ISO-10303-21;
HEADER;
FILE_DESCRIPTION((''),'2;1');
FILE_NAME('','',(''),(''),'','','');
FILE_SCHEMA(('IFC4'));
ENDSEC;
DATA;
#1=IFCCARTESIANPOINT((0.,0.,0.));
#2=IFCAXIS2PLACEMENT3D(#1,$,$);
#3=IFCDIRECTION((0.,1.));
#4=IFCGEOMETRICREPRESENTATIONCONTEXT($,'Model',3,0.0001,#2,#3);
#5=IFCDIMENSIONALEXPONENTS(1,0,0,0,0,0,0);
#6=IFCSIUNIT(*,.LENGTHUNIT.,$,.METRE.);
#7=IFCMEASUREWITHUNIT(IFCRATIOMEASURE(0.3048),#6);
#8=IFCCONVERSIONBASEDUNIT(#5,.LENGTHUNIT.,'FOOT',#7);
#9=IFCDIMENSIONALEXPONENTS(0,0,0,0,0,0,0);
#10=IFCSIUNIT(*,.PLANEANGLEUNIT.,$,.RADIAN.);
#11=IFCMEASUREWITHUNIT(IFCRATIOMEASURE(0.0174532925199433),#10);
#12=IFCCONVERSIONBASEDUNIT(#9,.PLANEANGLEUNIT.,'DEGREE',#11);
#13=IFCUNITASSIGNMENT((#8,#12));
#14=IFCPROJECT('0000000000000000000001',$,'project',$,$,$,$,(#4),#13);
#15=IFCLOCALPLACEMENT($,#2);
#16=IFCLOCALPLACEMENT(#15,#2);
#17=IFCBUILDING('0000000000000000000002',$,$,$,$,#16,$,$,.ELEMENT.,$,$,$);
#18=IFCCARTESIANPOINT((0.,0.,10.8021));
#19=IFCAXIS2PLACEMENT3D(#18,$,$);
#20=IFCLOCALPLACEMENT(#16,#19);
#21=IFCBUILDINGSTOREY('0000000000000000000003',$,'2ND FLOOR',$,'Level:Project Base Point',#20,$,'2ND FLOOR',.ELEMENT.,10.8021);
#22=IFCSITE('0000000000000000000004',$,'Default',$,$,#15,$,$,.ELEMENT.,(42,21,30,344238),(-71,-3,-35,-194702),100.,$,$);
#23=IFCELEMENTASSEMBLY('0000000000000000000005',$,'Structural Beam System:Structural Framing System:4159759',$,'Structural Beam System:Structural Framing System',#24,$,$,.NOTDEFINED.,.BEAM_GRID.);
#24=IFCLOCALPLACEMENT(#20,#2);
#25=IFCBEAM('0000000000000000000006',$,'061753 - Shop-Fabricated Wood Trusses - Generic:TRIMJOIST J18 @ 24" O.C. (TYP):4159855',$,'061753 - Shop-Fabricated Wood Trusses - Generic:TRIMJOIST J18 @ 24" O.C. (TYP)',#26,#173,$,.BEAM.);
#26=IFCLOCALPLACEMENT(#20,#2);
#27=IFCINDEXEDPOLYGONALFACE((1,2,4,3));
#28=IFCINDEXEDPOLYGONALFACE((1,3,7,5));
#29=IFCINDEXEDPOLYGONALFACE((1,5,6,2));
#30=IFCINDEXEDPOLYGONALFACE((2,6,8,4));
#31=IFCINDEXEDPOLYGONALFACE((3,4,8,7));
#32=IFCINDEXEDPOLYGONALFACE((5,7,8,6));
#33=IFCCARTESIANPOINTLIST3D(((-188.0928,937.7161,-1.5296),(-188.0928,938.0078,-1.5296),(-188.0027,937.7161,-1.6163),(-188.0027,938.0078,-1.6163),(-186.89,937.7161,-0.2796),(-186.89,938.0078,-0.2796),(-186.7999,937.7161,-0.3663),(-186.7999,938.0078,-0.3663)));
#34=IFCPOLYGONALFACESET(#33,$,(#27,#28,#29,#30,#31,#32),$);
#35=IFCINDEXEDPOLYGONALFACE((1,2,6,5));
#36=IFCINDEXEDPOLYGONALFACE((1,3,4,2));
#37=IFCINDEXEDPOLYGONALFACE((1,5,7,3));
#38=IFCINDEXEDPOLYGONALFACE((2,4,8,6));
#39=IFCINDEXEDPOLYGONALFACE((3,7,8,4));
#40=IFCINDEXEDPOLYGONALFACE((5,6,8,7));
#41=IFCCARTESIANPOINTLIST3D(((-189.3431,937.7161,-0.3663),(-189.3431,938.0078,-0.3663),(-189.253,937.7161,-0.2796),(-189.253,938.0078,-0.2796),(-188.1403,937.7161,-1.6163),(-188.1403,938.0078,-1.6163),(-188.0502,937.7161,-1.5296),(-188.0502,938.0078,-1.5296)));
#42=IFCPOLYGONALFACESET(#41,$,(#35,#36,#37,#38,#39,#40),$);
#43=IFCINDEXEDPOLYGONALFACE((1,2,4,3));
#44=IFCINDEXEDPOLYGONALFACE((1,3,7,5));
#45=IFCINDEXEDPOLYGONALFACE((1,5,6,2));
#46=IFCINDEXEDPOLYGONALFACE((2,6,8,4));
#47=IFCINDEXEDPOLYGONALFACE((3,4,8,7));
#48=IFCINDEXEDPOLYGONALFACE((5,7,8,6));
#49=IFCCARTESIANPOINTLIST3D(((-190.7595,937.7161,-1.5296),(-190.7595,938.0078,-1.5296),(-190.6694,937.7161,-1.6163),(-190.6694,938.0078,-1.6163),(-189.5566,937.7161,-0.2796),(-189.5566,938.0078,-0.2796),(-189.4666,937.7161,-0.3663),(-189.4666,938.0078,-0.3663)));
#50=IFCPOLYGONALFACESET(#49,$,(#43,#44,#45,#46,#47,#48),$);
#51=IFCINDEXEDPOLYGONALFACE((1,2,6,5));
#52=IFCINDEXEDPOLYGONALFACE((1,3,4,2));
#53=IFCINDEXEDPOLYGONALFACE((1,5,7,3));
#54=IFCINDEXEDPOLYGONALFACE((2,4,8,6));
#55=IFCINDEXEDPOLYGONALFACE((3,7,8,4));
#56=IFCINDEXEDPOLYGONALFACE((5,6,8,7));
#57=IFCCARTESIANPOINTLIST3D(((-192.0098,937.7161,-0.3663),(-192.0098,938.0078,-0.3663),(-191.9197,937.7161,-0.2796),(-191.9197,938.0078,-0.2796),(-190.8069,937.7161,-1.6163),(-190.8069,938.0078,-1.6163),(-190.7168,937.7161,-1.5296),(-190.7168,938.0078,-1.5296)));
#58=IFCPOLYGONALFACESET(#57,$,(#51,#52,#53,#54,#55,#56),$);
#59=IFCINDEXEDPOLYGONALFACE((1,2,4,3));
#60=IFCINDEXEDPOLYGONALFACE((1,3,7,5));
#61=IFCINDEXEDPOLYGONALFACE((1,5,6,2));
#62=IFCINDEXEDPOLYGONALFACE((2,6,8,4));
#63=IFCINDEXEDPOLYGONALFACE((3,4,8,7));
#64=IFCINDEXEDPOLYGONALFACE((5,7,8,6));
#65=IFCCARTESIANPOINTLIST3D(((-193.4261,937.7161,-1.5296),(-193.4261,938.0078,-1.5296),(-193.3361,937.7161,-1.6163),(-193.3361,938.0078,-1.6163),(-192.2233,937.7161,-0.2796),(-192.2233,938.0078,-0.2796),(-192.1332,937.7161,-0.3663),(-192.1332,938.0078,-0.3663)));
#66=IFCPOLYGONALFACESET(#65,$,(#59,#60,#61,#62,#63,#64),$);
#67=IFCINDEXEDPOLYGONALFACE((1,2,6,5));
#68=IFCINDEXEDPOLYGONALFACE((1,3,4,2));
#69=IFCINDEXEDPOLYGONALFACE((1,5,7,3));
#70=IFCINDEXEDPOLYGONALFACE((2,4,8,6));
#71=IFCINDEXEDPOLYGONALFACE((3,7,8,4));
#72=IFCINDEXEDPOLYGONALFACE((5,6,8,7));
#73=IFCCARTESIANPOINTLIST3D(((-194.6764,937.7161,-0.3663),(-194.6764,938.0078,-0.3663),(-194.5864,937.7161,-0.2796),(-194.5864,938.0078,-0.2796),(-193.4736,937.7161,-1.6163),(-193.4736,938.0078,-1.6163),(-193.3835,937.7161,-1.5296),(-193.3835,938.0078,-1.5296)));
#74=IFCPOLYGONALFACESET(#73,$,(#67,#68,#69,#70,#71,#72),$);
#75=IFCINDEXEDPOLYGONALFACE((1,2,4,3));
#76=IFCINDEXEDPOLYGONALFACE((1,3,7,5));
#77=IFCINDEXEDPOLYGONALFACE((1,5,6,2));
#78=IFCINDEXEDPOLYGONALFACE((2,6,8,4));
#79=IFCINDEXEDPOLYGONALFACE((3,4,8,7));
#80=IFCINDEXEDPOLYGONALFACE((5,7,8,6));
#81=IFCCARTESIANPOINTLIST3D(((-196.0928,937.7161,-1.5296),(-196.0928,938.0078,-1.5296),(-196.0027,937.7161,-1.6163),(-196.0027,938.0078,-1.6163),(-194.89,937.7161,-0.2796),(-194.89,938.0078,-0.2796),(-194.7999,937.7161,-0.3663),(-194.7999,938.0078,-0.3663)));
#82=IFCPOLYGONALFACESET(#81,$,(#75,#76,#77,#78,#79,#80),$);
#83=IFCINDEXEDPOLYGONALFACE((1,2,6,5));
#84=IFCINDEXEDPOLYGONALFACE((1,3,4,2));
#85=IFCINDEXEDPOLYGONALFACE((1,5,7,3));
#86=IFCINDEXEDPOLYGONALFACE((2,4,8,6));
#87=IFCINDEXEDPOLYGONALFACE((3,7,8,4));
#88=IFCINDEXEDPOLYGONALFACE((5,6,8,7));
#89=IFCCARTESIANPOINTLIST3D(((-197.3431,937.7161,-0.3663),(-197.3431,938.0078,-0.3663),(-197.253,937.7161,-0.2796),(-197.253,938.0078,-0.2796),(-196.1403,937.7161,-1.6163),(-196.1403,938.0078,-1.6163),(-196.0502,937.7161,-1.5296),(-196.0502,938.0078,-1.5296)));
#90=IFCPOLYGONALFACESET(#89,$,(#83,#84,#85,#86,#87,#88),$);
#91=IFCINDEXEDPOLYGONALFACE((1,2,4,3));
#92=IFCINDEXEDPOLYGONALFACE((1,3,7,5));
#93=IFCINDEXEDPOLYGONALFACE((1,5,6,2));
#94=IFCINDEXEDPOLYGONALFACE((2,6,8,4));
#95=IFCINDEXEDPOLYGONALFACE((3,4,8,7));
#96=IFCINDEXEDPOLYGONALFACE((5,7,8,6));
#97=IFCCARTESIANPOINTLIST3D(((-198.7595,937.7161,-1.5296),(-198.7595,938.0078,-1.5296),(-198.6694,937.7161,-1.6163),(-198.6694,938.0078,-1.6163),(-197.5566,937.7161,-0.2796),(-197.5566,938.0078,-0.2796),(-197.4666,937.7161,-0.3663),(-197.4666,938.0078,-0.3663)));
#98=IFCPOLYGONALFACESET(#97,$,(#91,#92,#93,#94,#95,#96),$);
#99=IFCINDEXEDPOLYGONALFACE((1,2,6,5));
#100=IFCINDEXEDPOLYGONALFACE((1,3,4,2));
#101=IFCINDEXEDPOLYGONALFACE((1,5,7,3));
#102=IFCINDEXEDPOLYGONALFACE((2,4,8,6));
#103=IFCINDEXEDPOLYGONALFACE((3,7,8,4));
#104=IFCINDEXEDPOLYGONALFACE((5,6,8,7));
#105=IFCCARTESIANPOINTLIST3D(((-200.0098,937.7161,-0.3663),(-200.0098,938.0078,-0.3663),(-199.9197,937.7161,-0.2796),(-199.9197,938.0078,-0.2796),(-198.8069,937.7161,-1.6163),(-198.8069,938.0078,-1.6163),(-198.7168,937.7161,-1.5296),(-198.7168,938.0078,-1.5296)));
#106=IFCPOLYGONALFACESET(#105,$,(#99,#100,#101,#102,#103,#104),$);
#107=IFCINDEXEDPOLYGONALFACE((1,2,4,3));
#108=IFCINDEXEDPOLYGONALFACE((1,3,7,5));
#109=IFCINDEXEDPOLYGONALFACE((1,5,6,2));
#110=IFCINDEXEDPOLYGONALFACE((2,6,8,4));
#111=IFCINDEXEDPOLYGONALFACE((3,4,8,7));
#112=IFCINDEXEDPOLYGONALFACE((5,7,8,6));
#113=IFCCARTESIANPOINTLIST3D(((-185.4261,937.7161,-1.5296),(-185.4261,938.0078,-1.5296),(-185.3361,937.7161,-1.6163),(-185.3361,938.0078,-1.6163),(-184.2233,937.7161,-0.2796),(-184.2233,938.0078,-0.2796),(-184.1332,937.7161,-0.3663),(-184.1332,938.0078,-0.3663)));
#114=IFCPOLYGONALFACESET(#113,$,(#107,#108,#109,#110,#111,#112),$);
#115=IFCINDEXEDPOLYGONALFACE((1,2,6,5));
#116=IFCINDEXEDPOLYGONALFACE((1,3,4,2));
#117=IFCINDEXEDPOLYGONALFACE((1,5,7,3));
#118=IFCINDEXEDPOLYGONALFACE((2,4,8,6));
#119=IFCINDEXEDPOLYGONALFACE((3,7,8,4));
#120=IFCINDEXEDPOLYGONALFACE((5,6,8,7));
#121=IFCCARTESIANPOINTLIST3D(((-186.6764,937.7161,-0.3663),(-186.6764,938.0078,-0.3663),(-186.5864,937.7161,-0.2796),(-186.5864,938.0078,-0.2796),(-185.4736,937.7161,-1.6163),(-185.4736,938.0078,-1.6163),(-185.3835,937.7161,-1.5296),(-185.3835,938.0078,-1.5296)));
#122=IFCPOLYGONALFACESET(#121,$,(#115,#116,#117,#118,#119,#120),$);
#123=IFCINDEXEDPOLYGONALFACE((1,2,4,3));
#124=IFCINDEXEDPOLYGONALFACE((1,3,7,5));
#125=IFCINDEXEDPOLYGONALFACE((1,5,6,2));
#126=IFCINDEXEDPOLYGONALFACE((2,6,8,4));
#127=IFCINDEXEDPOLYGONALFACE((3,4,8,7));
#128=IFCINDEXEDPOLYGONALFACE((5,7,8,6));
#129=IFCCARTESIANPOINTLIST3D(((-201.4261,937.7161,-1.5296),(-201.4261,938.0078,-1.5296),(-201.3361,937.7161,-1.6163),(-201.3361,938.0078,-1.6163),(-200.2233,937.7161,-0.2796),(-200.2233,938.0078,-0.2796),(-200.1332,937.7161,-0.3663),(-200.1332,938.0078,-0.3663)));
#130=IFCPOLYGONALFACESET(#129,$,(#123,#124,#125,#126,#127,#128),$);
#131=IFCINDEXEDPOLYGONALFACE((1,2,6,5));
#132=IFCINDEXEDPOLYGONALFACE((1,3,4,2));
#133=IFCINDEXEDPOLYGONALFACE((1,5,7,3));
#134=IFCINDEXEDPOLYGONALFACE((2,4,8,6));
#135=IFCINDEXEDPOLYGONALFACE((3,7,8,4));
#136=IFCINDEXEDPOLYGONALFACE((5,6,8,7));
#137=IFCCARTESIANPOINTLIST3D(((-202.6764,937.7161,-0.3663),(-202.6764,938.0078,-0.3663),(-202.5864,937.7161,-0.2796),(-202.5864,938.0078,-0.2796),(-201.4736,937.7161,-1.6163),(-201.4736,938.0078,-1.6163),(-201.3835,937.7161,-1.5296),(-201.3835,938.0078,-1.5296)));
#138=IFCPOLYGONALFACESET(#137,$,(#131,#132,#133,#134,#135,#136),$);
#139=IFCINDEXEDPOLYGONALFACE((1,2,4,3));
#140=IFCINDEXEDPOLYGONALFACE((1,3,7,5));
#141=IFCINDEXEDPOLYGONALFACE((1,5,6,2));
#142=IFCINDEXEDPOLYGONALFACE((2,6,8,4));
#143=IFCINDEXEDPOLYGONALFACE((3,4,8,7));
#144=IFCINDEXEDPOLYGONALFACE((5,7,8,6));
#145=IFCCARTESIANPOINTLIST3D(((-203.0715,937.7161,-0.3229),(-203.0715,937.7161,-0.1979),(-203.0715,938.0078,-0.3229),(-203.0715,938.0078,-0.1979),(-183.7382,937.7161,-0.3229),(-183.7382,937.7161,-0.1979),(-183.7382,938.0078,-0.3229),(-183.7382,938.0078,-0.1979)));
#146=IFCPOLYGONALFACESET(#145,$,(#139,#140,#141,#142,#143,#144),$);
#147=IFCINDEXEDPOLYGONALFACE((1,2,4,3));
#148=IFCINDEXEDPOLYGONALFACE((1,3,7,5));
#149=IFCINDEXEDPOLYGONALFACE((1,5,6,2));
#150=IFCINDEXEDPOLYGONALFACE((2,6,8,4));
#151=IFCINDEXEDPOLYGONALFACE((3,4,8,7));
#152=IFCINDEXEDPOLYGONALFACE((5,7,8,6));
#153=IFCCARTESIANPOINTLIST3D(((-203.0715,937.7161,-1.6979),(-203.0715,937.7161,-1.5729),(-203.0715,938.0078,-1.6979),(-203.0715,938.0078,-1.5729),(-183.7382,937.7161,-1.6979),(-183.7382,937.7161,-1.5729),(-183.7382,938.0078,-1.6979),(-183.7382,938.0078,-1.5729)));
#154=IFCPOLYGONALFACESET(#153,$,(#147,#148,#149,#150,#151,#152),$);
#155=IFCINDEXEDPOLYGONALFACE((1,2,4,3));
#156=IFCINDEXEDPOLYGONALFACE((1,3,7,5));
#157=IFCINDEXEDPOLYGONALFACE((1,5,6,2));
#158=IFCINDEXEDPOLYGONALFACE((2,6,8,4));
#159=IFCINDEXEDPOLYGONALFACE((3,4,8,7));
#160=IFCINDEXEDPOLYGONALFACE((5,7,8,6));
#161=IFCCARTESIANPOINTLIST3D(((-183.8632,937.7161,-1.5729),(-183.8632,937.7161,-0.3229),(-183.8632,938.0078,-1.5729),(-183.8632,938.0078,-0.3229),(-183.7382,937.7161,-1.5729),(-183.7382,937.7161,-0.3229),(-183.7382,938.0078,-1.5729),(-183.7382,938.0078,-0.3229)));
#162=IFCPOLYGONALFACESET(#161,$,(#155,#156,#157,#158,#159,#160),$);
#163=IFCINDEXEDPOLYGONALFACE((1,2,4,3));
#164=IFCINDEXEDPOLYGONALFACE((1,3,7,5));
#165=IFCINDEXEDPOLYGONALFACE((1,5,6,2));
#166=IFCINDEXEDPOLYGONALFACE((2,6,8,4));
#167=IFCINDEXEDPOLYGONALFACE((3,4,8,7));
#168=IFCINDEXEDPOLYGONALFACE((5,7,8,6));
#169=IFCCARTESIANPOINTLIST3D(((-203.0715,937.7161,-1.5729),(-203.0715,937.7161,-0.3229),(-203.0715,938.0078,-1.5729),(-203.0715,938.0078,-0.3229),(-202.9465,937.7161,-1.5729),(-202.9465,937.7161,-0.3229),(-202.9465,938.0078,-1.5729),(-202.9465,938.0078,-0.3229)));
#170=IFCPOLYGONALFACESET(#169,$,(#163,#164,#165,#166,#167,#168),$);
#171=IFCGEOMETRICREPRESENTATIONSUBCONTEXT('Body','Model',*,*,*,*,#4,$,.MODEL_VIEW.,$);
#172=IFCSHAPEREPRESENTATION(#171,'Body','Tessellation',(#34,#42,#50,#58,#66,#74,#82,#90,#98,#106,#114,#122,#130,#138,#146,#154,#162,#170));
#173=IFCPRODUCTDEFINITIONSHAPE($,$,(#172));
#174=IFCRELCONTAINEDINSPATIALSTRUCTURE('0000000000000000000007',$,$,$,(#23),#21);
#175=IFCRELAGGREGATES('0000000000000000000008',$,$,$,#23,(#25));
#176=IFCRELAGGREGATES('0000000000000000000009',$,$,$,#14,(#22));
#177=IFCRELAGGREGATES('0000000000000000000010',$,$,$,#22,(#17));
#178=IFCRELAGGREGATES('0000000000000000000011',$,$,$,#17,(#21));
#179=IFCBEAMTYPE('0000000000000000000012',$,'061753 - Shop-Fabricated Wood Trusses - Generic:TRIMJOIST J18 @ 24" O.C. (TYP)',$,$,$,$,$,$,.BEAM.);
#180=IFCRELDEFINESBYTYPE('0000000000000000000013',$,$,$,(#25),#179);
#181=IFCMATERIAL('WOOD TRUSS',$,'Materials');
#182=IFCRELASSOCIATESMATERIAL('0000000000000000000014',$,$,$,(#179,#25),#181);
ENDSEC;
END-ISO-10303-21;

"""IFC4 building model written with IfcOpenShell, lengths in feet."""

from ifc_helpers import new_model, entity, si_unit, converted_unit, direction, frame, frame_2d, origin, origin_2d_with_axis, place, context, subcontext, project, spatial, rectangle, extrude, source, transform, mapped, material, material_profile, profile_set, profile_usage, type_object, type_shapes, element, aggregate, save


model = new_model("IFC4")

# Units and contexts
model_context = context("Model", 3, precision=0.0001, world=origin(), true_north=direction((0.0, 1.0)))
body_context = subcontext(model_context, "Body", "Model", "MODEL_VIEW")
ifc_project = project(units=[converted_unit("LENGTHUNIT", "FOOT", entity("IfcRatioMeasure", 0.3048), si_unit("LENGTHUNIT", "METRE"), dimensions=[1, 0, 0, 0, 0, 0, 0]), converted_unit("PLANEANGLEUNIT", "DEGREE", entity("IfcRatioMeasure", 0.0174532925199433), si_unit("PLANEANGLEUNIT", "RADIAN"), dimensions=[0, 0, 0, 0, 0, 0, 0])], contexts=[model_context])

# Site, building, storey
site_placement = place(None, origin())
site = spatial("IfcSite", under=ifc_project, at=site_placement, Name="Default", CompositionType="ELEMENT", RefLatitude=(42, 21, 30, 344238), RefLongitude=(-71, -3, -35, -194702), RefElevation=100.0)
building_placement = place(site_placement, origin())
building = spatial("IfcBuilding", under=site, at=building_placement, CompositionType="ELEMENT")
storey_placement = place(building_placement, frame((0.0, 0.0, 10.8021)))
storey = spatial("IfcBuildingStorey", under=building, at=storey_placement, Name="2ND FLOOR", ObjectType="Level:Project Base Point", LongName="2ND FLOOR", CompositionType="ELEMENT", Elevation=10.8021)

# Element assembly, beam
ifc_material_1 = material(Name="WOOD TRUSS", Category="Materials")
ifc_material_profile_1 = material_profile(ifc_material_1, rectangle(XDim=1.7347, YDim=0.125, at=frame_2d((0.0, 0.0), x_axis=(1.0, 0.0))), Name="TRIMJOIST J18 @ 24\" O.C. (TYP)")
ifc_material_profile_2 = material_profile(ifc_material_1, rectangle(XDim=1.7347, YDim=0.125, at=frame_2d((0.0, 0.0), x_axis=(1.0, 0.0))), Name="TRIMJOIST J18 @ 24\" O.C. (TYP)")
ifc_material_profile_3 = material_profile(ifc_material_1, rectangle(XDim=1.7347, YDim=0.125, at=frame_2d((0.0, 0.0), x_axis=(1.0, 0.0))), Name="TRIMJOIST J18 @ 24\" O.C. (TYP)")
ifc_material_profile_4 = material_profile(ifc_material_1, rectangle(XDim=1.7347, YDim=0.125, at=frame_2d((0.0, 0.0), x_axis=(1.0, 0.0))), Name="TRIMJOIST J18 @ 24\" O.C. (TYP)")
ifc_material_profile_5 = material_profile(ifc_material_1, rectangle(XDim=1.7347, YDim=0.125, at=frame_2d((0.0, 0.0), x_axis=(1.0, 0.0))), Name="TRIMJOIST J18 @ 24\" O.C. (TYP)")
ifc_material_profile_6 = material_profile(ifc_material_1, rectangle(XDim=1.7347, YDim=0.125, at=frame_2d((0.0, 0.0), x_axis=(1.0, 0.0))), Name="TRIMJOIST J18 @ 24\" O.C. (TYP)")
ifc_material_profile_7 = material_profile(ifc_material_1, rectangle(XDim=1.7347, YDim=0.125, at=frame_2d((0.0, 0.0), x_axis=(1.0, 0.0))), Name="TRIMJOIST J18 @ 24\" O.C. (TYP)")
ifc_material_profile_8 = material_profile(ifc_material_1, rectangle(XDim=1.7347, YDim=0.125, at=frame_2d((0.0, 0.0), x_axis=(1.0, 0.0))), Name="TRIMJOIST J18 @ 24\" O.C. (TYP)")
ifc_material_profile_9 = material_profile(ifc_material_1, rectangle(XDim=1.7347, YDim=0.125, at=frame_2d((0.0, 0.0), x_axis=(1.0, 0.0))), Name="TRIMJOIST J18 @ 24\" O.C. (TYP)")
ifc_material_profile_10 = material_profile(ifc_material_1, rectangle(XDim=1.7347, YDim=0.125, at=origin_2d_with_axis()), Name="TRIMJOIST J18 @ 24\" O.C. (TYP)")
ifc_material_profile_11 = material_profile(ifc_material_1, rectangle(XDim=0.125, YDim=0.2917, at=origin_2d_with_axis()), Name="TRIMJOIST J18 @ 24\" O.C. (TYP)")
ifc_material_profile_12 = material_profile(ifc_material_1, rectangle(XDim=0.125, YDim=0.2917, at=origin_2d_with_axis()), Name="TRIMJOIST J18 @ 24\" O.C. (TYP)")
ifc_material_profile_13 = material_profile(ifc_material_1, rectangle(XDim=1.25, YDim=0.2917, at=origin_2d_with_axis()), Name="TRIMJOIST J18 @ 24\" O.C. (TYP)")
ifc_material_profile_14 = material_profile(ifc_material_1, rectangle(XDim=1.25, YDim=0.2917, at=origin_2d_with_axis()), Name="TRIMJOIST J18 @ 24\" O.C. (TYP)")
ifc_profile_set_1 = profile_set([ifc_material_profile_1, ifc_material_profile_2, ifc_material_profile_3, ifc_material_profile_4, ifc_material_profile_5, ifc_material_profile_6, ifc_material_profile_7, ifc_material_profile_8, ifc_material_profile_9, ifc_material_profile_10, ifc_material_profile_11, ifc_material_profile_12, ifc_material_profile_13, ifc_material_profile_14], Name="TRIMJOIST J18 @ 24\" O.C. (TYP)")
beam_type_1 = type_object("IfcBeamType", Name="061753 - Shop-Fabricated Wood Trusses - Generic:TRIMJOIST J18 @ 24\" O.C. (TYP)", PredefinedType="BEAM", material=ifc_profile_set_1)
shared_shape_1 = source(origin(), body_context, "Body", "SweptSolid", [
    extrude(rectangle(XDim=1.7347, YDim=0.125, at=frame_2d((0.0, 0.0), x_axis=(1.0, 0.0))), frame((5.9585, -0.1458, 0.0), z_axis=(0.0, 1.0, 0.0), x_axis=(0.693383, 0.0, 0.720569)), (0.0, 0.0, 1.0), 0.2917),
    extrude(rectangle(XDim=1.7347, YDim=0.125, at=origin_2d_with_axis()), frame((4.7082, -0.1458, 0.0), z_axis=(0.0, 1.0, 0.0), x_axis=(0.693383, 0.0, -0.720569)), (0.0, 0.0, 1.0), 0.2917),
    extrude(rectangle(XDim=1.7347, YDim=0.125, at=frame_2d((0.0, 0.0), x_axis=(1.0, 0.0))), frame((3.2918, -0.1458, 0.0), z_axis=(0.0, 1.0, 0.0), x_axis=(0.693383, 0.0, 0.720569)), (0.0, 0.0, 1.0), 0.2917),
    extrude(rectangle(XDim=1.7347, YDim=0.125, at=frame_2d((0.0, 0.0), x_axis=(1.0, 0.0))), frame((2.0415, -0.1458, 0.0), z_axis=(0.0, 1.0, 0.0), x_axis=(0.693383, 0.0, -0.720569)), (0.0, 0.0, 1.0), 0.2917),
    extrude(rectangle(XDim=1.7347, YDim=0.125, at=frame_2d((0.0, 0.0), x_axis=(1.0, 0.0))), frame((0.6251, -0.1458, 0.0), z_axis=(0.0, 1.0, 0.0), x_axis=(0.693383, 0.0, 0.720569)), (0.0, 0.0, 1.0), 0.2917),
    extrude(rectangle(XDim=1.7347, YDim=0.125, at=frame_2d((0.0, 0.0), x_axis=(1.0, 0.0))), frame((-0.6251, -0.1458, 0.0), z_axis=(0.0, 1.0, 0.0), x_axis=(0.693383, 0.0, -0.720569)), (0.0, 0.0, 1.0), 0.2917),
    extrude(rectangle(XDim=1.7347, YDim=0.125, at=frame_2d((0.0, 0.0), x_axis=(1.0, 0.0))), frame((-2.0415, -0.1458, 0.0), z_axis=(0.0, 1.0, 0.0), x_axis=(0.693383, 0.0, 0.720569)), (0.0, 0.0, 1.0), 0.2917),
    extrude(rectangle(XDim=1.7347, YDim=0.125, at=origin_2d_with_axis()), frame((-3.2918, -0.1458, 0.0), z_axis=(0.0, 1.0, 0.0), x_axis=(0.693383, 0.0, -0.720569)), (0.0, 0.0, 1.0), 0.2917),
    extrude(rectangle(XDim=1.7347, YDim=0.125, at=frame_2d((0.0, 0.0), x_axis=(1.0, 0.0))), frame((-4.7082, -0.1458, 0.0), z_axis=(0.0, 1.0, 0.0), x_axis=(0.693383, 0.0, 0.720569)), (0.0, 0.0, 1.0), 0.2917),
    extrude(rectangle(XDim=1.7347, YDim=0.125, at=frame_2d((0.0, 0.0), x_axis=(1.0, 0.0))), frame((-5.9585, -0.1458, 0.0), z_axis=(0.0, 1.0, 0.0), x_axis=(0.693383, 0.0, -0.720569)), (0.0, 0.0, 1.0), 0.2917),
    extrude(rectangle(XDim=1.7347, YDim=0.125, at=frame_2d((0.0, 0.0), x_axis=(1.0, 0.0))), frame((8.6251, -0.1458, 0.0), z_axis=(0.0, 1.0, 0.0), x_axis=(0.693383, 0.0, 0.720569)), (0.0, 0.0, 1.0), 0.2917),
    extrude(rectangle(XDim=1.7347, YDim=0.125, at=origin_2d_with_axis()), frame((7.3749, -0.1458, 0.0), z_axis=(0.0, 1.0, 0.0), x_axis=(0.693383, 0.0, -0.720569)), (0.0, 0.0, 1.0), 0.2917),
    extrude(rectangle(XDim=1.7347, YDim=0.125, at=frame_2d((0.0, 0.0), x_axis=(1.0, 0.0))), frame((-7.3749, -0.1458, 0.0), z_axis=(0.0, 1.0, 0.0), x_axis=(0.693383, 0.0, 0.720569)), (0.0, 0.0, 1.0), 0.2917),
    extrude(rectangle(XDim=1.7347, YDim=0.125, at=origin_2d_with_axis()), frame((-8.6251, -0.1458, 0.0), z_axis=(0.0, 1.0, 0.0), x_axis=(0.693383, 0.0, -0.720569)), (0.0, 0.0, 1.0), 0.2917),
    extrude(rectangle(XDim=0.125, YDim=0.2917, at=origin_2d_with_axis()), frame((-9.6667, 0.0, 0.6875), z_axis=(1.0, 0.0, 0.0), x_axis=(0.0, 0.0, -1.0)), (0.0, 0.0, 1.0), 19.3333),
    extrude(rectangle(XDim=0.125, YDim=0.2917, at=origin_2d_with_axis()), frame((-9.6667, 0.0, -0.6875), z_axis=(1.0, 0.0, 0.0), x_axis=(0.0, 0.0, -1.0)), (0.0, 0.0, 1.0), 19.3333),
    extrude(rectangle(XDim=1.25, YDim=0.2917, at=origin_2d_with_axis()), frame((9.5417, 0.0, 0.0), z_axis=(1.0, 0.0, 0.0), x_axis=(0.0, 0.0, -1.0)), (0.0, 0.0, 1.0), 0.125),
    extrude(rectangle(XDim=1.25, YDim=0.2917, at=origin_2d_with_axis()), frame((-9.6667, 0.0, 0.0), z_axis=(1.0, 0.0, 0.0), x_axis=(0.0, 0.0, -1.0)), (0.0, 0.0, 1.0), 0.125),
])
type_shapes(beam_type_1, [shared_shape_1])
assembly_1_placement = place(storey_placement, origin())
assembly_1 = element("IfcElementAssembly", 1, at=assembly_1_placement, inside=storey, Name="Structural Beam System:Structural Framing System:4159759", ObjectType="Structural Beam System:Structural Framing System", AssemblyPlace="NOTDEFINED", PredefinedType="BEAM_GRID")
ifc_profile_usage_1 = profile_usage(ifc_profile_set_1, cardinal=8)
beam_1_placement = place(assembly_1_placement, frame((-193.4048, 937.8619, -0.9479)))
beam_1 = element("IfcBeam", 2, at=beam_1_placement, type_object=beam_type_1, material=ifc_profile_usage_1, Name="061753 - Shop-Fabricated Wood Trusses - Generic:TRIMJOIST J18 @ 24\" O.C. (TYP):4159855", ObjectType="061753 - Shop-Fabricated Wood Trusses - Generic:TRIMJOIST J18 @ 24\" O.C. (TYP)", PredefinedType="BEAM", context=body_context, shape_type="MappedRepresentation", body=[
    mapped(shared_shape_1, transform((0.0, 0.0, 0.0), scale=1.0)),
])
aggregate(assembly_1, [beam_1])

save(model, "model.ifc")
